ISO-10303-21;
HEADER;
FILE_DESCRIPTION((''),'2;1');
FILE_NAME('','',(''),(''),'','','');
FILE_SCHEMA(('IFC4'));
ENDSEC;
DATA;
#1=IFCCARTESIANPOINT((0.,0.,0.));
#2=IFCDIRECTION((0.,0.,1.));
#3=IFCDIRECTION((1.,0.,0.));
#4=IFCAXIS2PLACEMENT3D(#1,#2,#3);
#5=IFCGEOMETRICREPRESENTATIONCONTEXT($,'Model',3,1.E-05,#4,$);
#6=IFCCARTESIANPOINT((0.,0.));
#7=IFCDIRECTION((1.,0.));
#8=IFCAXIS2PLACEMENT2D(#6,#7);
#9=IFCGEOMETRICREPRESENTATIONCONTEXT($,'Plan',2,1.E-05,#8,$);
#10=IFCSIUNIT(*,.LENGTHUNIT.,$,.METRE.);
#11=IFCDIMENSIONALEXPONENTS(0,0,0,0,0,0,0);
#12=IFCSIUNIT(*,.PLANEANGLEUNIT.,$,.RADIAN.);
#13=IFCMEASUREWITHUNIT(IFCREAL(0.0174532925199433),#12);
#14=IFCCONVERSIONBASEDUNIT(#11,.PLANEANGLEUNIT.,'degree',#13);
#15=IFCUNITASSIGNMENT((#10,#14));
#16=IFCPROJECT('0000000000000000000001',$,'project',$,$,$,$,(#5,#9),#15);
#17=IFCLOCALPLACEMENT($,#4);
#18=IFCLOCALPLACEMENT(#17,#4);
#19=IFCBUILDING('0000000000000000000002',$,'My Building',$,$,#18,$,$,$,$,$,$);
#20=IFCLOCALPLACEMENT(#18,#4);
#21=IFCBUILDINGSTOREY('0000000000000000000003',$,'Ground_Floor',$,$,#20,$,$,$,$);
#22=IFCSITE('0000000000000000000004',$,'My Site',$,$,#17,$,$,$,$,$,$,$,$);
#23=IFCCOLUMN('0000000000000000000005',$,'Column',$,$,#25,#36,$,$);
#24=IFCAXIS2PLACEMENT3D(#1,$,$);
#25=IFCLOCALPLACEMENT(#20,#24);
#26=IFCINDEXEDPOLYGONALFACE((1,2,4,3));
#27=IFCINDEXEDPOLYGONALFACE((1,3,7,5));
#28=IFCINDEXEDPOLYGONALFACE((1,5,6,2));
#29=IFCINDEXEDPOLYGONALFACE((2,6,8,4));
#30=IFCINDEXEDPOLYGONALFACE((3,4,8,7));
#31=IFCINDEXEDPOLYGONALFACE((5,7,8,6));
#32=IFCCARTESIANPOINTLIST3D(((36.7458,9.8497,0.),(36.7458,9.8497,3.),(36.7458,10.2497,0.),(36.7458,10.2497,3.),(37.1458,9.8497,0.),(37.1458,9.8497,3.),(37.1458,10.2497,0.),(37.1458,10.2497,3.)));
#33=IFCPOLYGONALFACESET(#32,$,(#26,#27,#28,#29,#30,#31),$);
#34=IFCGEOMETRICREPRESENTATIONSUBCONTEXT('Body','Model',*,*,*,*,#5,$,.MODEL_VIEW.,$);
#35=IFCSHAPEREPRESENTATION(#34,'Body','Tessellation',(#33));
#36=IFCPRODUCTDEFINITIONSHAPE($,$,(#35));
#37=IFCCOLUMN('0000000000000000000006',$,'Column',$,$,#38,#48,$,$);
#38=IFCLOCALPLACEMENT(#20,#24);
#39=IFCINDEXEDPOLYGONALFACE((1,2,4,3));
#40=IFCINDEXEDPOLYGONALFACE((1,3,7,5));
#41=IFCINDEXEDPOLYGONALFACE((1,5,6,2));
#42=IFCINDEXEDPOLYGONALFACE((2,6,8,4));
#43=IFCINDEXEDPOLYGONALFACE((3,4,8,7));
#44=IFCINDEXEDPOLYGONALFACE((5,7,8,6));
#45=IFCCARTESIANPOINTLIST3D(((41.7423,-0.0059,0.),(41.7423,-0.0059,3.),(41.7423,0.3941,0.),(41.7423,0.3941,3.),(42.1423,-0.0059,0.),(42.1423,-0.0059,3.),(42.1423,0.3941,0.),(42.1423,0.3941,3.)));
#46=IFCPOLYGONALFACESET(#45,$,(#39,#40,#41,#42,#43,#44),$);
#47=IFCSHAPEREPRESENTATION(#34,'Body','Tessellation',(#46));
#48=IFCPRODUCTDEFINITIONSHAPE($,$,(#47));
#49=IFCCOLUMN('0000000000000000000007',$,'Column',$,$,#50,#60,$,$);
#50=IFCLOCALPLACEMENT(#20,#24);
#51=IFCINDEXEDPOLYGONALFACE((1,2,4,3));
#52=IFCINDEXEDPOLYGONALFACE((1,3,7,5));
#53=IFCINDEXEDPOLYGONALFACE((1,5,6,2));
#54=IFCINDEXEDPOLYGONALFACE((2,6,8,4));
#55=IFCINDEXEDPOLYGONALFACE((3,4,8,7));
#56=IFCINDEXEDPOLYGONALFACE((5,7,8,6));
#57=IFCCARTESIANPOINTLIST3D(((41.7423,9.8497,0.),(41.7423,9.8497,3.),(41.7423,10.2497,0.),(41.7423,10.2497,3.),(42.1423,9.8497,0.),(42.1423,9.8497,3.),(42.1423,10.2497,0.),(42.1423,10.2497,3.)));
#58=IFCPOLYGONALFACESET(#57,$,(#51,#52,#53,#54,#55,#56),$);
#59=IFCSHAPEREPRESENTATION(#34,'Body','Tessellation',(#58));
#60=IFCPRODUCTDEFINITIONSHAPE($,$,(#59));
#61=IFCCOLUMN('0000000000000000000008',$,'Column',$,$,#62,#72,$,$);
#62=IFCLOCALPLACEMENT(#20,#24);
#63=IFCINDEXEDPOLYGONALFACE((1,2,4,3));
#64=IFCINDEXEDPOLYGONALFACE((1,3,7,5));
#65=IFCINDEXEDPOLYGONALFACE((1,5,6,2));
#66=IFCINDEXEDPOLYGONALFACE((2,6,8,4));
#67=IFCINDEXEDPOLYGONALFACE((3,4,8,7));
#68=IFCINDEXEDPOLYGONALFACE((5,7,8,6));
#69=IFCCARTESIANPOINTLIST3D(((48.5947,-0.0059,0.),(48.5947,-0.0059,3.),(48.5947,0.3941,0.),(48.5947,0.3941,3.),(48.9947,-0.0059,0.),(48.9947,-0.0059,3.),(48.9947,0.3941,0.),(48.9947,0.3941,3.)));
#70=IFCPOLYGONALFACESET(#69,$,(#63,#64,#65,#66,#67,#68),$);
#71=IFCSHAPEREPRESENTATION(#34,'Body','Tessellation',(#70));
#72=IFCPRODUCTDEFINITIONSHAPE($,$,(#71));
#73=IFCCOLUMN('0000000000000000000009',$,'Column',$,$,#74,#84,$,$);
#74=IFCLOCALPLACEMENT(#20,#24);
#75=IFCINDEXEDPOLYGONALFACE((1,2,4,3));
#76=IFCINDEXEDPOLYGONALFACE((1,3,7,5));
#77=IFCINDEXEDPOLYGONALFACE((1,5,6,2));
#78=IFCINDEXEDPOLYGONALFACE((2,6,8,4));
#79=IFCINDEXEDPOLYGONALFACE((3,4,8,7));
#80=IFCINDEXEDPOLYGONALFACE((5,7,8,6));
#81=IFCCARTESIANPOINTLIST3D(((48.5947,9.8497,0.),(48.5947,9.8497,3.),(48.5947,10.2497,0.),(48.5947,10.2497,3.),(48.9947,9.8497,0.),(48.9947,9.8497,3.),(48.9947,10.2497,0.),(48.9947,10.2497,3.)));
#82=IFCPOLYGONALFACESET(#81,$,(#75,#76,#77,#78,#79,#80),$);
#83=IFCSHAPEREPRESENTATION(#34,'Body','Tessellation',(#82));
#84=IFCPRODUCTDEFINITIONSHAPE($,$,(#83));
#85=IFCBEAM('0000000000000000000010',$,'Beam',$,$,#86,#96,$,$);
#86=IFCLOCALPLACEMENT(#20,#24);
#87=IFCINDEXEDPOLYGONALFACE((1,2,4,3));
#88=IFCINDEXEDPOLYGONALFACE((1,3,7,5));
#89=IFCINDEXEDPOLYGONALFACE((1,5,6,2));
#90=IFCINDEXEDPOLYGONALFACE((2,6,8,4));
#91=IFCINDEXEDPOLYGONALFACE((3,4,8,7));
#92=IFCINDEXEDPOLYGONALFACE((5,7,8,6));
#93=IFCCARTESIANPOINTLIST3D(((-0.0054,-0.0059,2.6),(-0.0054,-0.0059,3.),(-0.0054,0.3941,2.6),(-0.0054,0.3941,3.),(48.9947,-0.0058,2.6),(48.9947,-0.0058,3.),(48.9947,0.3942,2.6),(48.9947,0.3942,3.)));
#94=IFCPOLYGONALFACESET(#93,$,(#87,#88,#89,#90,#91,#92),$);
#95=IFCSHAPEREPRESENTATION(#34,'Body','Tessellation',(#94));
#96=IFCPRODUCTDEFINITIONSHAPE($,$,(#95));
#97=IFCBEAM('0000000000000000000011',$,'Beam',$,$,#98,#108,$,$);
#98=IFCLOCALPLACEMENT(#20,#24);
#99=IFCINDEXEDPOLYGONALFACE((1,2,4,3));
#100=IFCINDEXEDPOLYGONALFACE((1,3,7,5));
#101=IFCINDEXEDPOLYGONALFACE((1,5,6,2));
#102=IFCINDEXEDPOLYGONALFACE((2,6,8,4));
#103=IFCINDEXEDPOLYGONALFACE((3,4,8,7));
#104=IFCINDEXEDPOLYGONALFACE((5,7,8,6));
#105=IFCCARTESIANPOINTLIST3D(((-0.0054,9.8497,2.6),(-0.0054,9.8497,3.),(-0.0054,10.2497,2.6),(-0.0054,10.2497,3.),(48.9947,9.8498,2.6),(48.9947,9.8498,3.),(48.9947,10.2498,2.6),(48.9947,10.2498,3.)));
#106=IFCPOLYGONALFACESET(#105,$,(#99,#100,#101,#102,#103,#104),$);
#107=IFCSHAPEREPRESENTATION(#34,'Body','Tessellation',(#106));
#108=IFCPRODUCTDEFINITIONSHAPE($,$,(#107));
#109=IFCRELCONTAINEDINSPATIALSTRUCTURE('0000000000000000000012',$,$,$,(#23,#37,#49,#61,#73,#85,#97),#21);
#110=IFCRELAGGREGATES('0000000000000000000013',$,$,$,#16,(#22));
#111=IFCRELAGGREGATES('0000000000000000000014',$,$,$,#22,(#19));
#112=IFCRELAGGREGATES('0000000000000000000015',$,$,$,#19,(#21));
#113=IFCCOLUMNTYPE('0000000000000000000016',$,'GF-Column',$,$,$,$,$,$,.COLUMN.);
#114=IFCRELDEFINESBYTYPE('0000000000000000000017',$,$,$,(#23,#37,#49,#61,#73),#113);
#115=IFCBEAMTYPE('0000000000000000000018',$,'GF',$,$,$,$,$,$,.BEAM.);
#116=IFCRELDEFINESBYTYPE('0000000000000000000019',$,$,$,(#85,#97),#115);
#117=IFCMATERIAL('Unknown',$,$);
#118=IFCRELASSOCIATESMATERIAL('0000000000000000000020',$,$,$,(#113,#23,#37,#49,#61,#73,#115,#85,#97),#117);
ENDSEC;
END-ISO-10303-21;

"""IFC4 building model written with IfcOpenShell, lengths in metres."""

from ifc_helpers import new_model, entity, si_unit, converted_unit, frame, origin_with_axes, origin_2d_with_axis, place, context, subcontext, project, spatial, rectangle, extrude, material, material_profile, profile_set, profile_usage, type_object, element, save


model = new_model("IFC4")

# Units and contexts
model_context = context("Model", 3, precision=1e-05, world=origin_with_axes())
plan_context = context("Plan", 2, precision=1e-05, world=origin_2d_with_axis())
body_context_1 = subcontext(model_context, "Body", "Model", "MODEL_VIEW")
ifc_project = project(units=[si_unit("LENGTHUNIT", "METRE"), converted_unit("PLANEANGLEUNIT", "degree", entity("IfcReal", 0.0174532925199433), si_unit("PLANEANGLEUNIT", "RADIAN"), dimensions=[0, 0, 0, 0, 0, 0, 0])], contexts=[model_context, plan_context])

# Site, building, storey
site_placement = place(None, origin_with_axes())
site = spatial("IfcSite", under=ifc_project, at=site_placement, Name="My Site")
building_placement = place(site_placement, origin_with_axes())
building = spatial("IfcBuilding", under=site, at=building_placement, Name="My Building")
storey_placement = place(building_placement, origin_with_axes())
storey = spatial("IfcBuildingStorey", under=building, at=storey_placement, Name="Ground_Floor")

# Columns
ifc_material = material(Name="Unknown")
ifc_material_profile_1 = material_profile(ifc_material, rectangle(XDim=0.4, YDim=0.4))
ifc_profile_set_1 = profile_set([ifc_material_profile_1])
ifc_profile_usage_1 = profile_usage(ifc_profile_set_1, cardinal=5)
column_type = type_object("IfcColumnType", Name="GF-Column", PredefinedType="COLUMN", material=ifc_profile_set_1)
column_1_placement = place(storey_placement, frame((36.9458, 10.0497, 0.0), z_axis=(0.0, 0.0, 1.0), x_axis=(1.0, 0.0, 0.0)))
element("IfcColumn", 1, at=column_1_placement, inside=storey, type_object=column_type, material=ifc_profile_usage_1, Name="Column", context=body_context_1, shape_type="SweptSolid", body=[
    extrude(rectangle(XDim=0.4, YDim=0.4), origin_with_axes(), (0.0, 0.0, 1.0), 3.0),
])
ifc_profile_usage_2 = profile_usage(ifc_profile_set_1, cardinal=5)
column_2_placement = place(storey_placement, frame((41.9423, 0.1941, 0.0), z_axis=(0.0, 0.0, 1.0), x_axis=(1.0, 0.0, 0.0)))
element("IfcColumn", 2, at=column_2_placement, inside=storey, type_object=column_type, material=ifc_profile_usage_2, Name="Column", context=body_context_1, shape_type="SweptSolid", body=[
    extrude(rectangle(XDim=0.4, YDim=0.4), origin_with_axes(), (0.0, 0.0, 1.0), 3.0),
])
ifc_profile_usage_3 = profile_usage(ifc_profile_set_1, cardinal=5)
column_3_placement = place(storey_placement, frame((41.9423, 10.0497, 0.0), z_axis=(0.0, 0.0, 1.0), x_axis=(1.0, 0.0, 0.0)))
element("IfcColumn", 3, at=column_3_placement, inside=storey, type_object=column_type, material=ifc_profile_usage_3, Name="Column", context=body_context_1, shape_type="SweptSolid", body=[
    extrude(rectangle(XDim=0.4, YDim=0.4), origin_with_axes(), (0.0, 0.0, 1.0), 3.0),
])
ifc_profile_usage_4 = profile_usage(ifc_profile_set_1, cardinal=5)
column_4_placement = place(storey_placement, frame((48.7947, 0.1941, 0.0), z_axis=(0.0, 0.0, 1.0), x_axis=(1.0, 0.0, 0.0)))
element("IfcColumn", 4, at=column_4_placement, inside=storey, type_object=column_type, material=ifc_profile_usage_4, Name="Column", context=body_context_1, shape_type="SweptSolid", body=[
    extrude(rectangle(XDim=0.4, YDim=0.4), origin_with_axes(), (0.0, 0.0, 1.0), 3.0),
])
ifc_profile_usage_5 = profile_usage(ifc_profile_set_1, cardinal=5)
column_5_placement = place(storey_placement, frame((48.7947, 10.0497, 0.0), z_axis=(0.0, 0.0, 1.0), x_axis=(1.0, 0.0, 0.0)))
element("IfcColumn", 5, at=column_5_placement, inside=storey, type_object=column_type, material=ifc_profile_usage_5, Name="Column", context=body_context_1, shape_type="SweptSolid", body=[
    extrude(rectangle(XDim=0.4, YDim=0.4), origin_with_axes(), (0.0, 0.0, 1.0), 3.0),
])

# Beams
ifc_material_profile_2 = material_profile(ifc_material, rectangle(XDim=0.4, YDim=0.4))
ifc_profile_set_2 = profile_set([ifc_material_profile_2])
ifc_profile_usage_6 = profile_usage(ifc_profile_set_2, cardinal=5)
beam_type = type_object("IfcBeamType", Name="GF", PredefinedType="BEAM", material=ifc_profile_set_2)
beam_1_placement = place(storey_placement, frame((48.9947, 0.1942, 2.8), z_axis=(-1.0, 0.0, 0.0), x_axis=(0.0, -1.0, 0.0)))
element("IfcBeam", 6, at=beam_1_placement, inside=storey, type_object=beam_type, material=ifc_profile_usage_6, Name="Beam", context=body_context_1, shape_type="SweptSolid", body=[
    extrude(rectangle(XDim=0.4, YDim=0.4), origin_with_axes(), (0.0, 0.0, 1.0), 49.0001),
])
ifc_profile_usage_7 = profile_usage(ifc_profile_set_2, cardinal=5)
beam_2_placement = place(storey_placement, frame((48.9947, 10.0498, 2.8), z_axis=(-1.0, 0.0, 0.0), x_axis=(0.0, -1.0, 0.0)))
element("IfcBeam", 7, at=beam_2_placement, inside=storey, type_object=beam_type, material=ifc_profile_usage_7, Name="Beam", context=body_context_1, shape_type="SweptSolid", body=[
    extrude(rectangle(XDim=0.4, YDim=0.4), origin_with_axes(), (0.0, 0.0, 1.0), 49.0001),
])

save(model, "model.ifc")
